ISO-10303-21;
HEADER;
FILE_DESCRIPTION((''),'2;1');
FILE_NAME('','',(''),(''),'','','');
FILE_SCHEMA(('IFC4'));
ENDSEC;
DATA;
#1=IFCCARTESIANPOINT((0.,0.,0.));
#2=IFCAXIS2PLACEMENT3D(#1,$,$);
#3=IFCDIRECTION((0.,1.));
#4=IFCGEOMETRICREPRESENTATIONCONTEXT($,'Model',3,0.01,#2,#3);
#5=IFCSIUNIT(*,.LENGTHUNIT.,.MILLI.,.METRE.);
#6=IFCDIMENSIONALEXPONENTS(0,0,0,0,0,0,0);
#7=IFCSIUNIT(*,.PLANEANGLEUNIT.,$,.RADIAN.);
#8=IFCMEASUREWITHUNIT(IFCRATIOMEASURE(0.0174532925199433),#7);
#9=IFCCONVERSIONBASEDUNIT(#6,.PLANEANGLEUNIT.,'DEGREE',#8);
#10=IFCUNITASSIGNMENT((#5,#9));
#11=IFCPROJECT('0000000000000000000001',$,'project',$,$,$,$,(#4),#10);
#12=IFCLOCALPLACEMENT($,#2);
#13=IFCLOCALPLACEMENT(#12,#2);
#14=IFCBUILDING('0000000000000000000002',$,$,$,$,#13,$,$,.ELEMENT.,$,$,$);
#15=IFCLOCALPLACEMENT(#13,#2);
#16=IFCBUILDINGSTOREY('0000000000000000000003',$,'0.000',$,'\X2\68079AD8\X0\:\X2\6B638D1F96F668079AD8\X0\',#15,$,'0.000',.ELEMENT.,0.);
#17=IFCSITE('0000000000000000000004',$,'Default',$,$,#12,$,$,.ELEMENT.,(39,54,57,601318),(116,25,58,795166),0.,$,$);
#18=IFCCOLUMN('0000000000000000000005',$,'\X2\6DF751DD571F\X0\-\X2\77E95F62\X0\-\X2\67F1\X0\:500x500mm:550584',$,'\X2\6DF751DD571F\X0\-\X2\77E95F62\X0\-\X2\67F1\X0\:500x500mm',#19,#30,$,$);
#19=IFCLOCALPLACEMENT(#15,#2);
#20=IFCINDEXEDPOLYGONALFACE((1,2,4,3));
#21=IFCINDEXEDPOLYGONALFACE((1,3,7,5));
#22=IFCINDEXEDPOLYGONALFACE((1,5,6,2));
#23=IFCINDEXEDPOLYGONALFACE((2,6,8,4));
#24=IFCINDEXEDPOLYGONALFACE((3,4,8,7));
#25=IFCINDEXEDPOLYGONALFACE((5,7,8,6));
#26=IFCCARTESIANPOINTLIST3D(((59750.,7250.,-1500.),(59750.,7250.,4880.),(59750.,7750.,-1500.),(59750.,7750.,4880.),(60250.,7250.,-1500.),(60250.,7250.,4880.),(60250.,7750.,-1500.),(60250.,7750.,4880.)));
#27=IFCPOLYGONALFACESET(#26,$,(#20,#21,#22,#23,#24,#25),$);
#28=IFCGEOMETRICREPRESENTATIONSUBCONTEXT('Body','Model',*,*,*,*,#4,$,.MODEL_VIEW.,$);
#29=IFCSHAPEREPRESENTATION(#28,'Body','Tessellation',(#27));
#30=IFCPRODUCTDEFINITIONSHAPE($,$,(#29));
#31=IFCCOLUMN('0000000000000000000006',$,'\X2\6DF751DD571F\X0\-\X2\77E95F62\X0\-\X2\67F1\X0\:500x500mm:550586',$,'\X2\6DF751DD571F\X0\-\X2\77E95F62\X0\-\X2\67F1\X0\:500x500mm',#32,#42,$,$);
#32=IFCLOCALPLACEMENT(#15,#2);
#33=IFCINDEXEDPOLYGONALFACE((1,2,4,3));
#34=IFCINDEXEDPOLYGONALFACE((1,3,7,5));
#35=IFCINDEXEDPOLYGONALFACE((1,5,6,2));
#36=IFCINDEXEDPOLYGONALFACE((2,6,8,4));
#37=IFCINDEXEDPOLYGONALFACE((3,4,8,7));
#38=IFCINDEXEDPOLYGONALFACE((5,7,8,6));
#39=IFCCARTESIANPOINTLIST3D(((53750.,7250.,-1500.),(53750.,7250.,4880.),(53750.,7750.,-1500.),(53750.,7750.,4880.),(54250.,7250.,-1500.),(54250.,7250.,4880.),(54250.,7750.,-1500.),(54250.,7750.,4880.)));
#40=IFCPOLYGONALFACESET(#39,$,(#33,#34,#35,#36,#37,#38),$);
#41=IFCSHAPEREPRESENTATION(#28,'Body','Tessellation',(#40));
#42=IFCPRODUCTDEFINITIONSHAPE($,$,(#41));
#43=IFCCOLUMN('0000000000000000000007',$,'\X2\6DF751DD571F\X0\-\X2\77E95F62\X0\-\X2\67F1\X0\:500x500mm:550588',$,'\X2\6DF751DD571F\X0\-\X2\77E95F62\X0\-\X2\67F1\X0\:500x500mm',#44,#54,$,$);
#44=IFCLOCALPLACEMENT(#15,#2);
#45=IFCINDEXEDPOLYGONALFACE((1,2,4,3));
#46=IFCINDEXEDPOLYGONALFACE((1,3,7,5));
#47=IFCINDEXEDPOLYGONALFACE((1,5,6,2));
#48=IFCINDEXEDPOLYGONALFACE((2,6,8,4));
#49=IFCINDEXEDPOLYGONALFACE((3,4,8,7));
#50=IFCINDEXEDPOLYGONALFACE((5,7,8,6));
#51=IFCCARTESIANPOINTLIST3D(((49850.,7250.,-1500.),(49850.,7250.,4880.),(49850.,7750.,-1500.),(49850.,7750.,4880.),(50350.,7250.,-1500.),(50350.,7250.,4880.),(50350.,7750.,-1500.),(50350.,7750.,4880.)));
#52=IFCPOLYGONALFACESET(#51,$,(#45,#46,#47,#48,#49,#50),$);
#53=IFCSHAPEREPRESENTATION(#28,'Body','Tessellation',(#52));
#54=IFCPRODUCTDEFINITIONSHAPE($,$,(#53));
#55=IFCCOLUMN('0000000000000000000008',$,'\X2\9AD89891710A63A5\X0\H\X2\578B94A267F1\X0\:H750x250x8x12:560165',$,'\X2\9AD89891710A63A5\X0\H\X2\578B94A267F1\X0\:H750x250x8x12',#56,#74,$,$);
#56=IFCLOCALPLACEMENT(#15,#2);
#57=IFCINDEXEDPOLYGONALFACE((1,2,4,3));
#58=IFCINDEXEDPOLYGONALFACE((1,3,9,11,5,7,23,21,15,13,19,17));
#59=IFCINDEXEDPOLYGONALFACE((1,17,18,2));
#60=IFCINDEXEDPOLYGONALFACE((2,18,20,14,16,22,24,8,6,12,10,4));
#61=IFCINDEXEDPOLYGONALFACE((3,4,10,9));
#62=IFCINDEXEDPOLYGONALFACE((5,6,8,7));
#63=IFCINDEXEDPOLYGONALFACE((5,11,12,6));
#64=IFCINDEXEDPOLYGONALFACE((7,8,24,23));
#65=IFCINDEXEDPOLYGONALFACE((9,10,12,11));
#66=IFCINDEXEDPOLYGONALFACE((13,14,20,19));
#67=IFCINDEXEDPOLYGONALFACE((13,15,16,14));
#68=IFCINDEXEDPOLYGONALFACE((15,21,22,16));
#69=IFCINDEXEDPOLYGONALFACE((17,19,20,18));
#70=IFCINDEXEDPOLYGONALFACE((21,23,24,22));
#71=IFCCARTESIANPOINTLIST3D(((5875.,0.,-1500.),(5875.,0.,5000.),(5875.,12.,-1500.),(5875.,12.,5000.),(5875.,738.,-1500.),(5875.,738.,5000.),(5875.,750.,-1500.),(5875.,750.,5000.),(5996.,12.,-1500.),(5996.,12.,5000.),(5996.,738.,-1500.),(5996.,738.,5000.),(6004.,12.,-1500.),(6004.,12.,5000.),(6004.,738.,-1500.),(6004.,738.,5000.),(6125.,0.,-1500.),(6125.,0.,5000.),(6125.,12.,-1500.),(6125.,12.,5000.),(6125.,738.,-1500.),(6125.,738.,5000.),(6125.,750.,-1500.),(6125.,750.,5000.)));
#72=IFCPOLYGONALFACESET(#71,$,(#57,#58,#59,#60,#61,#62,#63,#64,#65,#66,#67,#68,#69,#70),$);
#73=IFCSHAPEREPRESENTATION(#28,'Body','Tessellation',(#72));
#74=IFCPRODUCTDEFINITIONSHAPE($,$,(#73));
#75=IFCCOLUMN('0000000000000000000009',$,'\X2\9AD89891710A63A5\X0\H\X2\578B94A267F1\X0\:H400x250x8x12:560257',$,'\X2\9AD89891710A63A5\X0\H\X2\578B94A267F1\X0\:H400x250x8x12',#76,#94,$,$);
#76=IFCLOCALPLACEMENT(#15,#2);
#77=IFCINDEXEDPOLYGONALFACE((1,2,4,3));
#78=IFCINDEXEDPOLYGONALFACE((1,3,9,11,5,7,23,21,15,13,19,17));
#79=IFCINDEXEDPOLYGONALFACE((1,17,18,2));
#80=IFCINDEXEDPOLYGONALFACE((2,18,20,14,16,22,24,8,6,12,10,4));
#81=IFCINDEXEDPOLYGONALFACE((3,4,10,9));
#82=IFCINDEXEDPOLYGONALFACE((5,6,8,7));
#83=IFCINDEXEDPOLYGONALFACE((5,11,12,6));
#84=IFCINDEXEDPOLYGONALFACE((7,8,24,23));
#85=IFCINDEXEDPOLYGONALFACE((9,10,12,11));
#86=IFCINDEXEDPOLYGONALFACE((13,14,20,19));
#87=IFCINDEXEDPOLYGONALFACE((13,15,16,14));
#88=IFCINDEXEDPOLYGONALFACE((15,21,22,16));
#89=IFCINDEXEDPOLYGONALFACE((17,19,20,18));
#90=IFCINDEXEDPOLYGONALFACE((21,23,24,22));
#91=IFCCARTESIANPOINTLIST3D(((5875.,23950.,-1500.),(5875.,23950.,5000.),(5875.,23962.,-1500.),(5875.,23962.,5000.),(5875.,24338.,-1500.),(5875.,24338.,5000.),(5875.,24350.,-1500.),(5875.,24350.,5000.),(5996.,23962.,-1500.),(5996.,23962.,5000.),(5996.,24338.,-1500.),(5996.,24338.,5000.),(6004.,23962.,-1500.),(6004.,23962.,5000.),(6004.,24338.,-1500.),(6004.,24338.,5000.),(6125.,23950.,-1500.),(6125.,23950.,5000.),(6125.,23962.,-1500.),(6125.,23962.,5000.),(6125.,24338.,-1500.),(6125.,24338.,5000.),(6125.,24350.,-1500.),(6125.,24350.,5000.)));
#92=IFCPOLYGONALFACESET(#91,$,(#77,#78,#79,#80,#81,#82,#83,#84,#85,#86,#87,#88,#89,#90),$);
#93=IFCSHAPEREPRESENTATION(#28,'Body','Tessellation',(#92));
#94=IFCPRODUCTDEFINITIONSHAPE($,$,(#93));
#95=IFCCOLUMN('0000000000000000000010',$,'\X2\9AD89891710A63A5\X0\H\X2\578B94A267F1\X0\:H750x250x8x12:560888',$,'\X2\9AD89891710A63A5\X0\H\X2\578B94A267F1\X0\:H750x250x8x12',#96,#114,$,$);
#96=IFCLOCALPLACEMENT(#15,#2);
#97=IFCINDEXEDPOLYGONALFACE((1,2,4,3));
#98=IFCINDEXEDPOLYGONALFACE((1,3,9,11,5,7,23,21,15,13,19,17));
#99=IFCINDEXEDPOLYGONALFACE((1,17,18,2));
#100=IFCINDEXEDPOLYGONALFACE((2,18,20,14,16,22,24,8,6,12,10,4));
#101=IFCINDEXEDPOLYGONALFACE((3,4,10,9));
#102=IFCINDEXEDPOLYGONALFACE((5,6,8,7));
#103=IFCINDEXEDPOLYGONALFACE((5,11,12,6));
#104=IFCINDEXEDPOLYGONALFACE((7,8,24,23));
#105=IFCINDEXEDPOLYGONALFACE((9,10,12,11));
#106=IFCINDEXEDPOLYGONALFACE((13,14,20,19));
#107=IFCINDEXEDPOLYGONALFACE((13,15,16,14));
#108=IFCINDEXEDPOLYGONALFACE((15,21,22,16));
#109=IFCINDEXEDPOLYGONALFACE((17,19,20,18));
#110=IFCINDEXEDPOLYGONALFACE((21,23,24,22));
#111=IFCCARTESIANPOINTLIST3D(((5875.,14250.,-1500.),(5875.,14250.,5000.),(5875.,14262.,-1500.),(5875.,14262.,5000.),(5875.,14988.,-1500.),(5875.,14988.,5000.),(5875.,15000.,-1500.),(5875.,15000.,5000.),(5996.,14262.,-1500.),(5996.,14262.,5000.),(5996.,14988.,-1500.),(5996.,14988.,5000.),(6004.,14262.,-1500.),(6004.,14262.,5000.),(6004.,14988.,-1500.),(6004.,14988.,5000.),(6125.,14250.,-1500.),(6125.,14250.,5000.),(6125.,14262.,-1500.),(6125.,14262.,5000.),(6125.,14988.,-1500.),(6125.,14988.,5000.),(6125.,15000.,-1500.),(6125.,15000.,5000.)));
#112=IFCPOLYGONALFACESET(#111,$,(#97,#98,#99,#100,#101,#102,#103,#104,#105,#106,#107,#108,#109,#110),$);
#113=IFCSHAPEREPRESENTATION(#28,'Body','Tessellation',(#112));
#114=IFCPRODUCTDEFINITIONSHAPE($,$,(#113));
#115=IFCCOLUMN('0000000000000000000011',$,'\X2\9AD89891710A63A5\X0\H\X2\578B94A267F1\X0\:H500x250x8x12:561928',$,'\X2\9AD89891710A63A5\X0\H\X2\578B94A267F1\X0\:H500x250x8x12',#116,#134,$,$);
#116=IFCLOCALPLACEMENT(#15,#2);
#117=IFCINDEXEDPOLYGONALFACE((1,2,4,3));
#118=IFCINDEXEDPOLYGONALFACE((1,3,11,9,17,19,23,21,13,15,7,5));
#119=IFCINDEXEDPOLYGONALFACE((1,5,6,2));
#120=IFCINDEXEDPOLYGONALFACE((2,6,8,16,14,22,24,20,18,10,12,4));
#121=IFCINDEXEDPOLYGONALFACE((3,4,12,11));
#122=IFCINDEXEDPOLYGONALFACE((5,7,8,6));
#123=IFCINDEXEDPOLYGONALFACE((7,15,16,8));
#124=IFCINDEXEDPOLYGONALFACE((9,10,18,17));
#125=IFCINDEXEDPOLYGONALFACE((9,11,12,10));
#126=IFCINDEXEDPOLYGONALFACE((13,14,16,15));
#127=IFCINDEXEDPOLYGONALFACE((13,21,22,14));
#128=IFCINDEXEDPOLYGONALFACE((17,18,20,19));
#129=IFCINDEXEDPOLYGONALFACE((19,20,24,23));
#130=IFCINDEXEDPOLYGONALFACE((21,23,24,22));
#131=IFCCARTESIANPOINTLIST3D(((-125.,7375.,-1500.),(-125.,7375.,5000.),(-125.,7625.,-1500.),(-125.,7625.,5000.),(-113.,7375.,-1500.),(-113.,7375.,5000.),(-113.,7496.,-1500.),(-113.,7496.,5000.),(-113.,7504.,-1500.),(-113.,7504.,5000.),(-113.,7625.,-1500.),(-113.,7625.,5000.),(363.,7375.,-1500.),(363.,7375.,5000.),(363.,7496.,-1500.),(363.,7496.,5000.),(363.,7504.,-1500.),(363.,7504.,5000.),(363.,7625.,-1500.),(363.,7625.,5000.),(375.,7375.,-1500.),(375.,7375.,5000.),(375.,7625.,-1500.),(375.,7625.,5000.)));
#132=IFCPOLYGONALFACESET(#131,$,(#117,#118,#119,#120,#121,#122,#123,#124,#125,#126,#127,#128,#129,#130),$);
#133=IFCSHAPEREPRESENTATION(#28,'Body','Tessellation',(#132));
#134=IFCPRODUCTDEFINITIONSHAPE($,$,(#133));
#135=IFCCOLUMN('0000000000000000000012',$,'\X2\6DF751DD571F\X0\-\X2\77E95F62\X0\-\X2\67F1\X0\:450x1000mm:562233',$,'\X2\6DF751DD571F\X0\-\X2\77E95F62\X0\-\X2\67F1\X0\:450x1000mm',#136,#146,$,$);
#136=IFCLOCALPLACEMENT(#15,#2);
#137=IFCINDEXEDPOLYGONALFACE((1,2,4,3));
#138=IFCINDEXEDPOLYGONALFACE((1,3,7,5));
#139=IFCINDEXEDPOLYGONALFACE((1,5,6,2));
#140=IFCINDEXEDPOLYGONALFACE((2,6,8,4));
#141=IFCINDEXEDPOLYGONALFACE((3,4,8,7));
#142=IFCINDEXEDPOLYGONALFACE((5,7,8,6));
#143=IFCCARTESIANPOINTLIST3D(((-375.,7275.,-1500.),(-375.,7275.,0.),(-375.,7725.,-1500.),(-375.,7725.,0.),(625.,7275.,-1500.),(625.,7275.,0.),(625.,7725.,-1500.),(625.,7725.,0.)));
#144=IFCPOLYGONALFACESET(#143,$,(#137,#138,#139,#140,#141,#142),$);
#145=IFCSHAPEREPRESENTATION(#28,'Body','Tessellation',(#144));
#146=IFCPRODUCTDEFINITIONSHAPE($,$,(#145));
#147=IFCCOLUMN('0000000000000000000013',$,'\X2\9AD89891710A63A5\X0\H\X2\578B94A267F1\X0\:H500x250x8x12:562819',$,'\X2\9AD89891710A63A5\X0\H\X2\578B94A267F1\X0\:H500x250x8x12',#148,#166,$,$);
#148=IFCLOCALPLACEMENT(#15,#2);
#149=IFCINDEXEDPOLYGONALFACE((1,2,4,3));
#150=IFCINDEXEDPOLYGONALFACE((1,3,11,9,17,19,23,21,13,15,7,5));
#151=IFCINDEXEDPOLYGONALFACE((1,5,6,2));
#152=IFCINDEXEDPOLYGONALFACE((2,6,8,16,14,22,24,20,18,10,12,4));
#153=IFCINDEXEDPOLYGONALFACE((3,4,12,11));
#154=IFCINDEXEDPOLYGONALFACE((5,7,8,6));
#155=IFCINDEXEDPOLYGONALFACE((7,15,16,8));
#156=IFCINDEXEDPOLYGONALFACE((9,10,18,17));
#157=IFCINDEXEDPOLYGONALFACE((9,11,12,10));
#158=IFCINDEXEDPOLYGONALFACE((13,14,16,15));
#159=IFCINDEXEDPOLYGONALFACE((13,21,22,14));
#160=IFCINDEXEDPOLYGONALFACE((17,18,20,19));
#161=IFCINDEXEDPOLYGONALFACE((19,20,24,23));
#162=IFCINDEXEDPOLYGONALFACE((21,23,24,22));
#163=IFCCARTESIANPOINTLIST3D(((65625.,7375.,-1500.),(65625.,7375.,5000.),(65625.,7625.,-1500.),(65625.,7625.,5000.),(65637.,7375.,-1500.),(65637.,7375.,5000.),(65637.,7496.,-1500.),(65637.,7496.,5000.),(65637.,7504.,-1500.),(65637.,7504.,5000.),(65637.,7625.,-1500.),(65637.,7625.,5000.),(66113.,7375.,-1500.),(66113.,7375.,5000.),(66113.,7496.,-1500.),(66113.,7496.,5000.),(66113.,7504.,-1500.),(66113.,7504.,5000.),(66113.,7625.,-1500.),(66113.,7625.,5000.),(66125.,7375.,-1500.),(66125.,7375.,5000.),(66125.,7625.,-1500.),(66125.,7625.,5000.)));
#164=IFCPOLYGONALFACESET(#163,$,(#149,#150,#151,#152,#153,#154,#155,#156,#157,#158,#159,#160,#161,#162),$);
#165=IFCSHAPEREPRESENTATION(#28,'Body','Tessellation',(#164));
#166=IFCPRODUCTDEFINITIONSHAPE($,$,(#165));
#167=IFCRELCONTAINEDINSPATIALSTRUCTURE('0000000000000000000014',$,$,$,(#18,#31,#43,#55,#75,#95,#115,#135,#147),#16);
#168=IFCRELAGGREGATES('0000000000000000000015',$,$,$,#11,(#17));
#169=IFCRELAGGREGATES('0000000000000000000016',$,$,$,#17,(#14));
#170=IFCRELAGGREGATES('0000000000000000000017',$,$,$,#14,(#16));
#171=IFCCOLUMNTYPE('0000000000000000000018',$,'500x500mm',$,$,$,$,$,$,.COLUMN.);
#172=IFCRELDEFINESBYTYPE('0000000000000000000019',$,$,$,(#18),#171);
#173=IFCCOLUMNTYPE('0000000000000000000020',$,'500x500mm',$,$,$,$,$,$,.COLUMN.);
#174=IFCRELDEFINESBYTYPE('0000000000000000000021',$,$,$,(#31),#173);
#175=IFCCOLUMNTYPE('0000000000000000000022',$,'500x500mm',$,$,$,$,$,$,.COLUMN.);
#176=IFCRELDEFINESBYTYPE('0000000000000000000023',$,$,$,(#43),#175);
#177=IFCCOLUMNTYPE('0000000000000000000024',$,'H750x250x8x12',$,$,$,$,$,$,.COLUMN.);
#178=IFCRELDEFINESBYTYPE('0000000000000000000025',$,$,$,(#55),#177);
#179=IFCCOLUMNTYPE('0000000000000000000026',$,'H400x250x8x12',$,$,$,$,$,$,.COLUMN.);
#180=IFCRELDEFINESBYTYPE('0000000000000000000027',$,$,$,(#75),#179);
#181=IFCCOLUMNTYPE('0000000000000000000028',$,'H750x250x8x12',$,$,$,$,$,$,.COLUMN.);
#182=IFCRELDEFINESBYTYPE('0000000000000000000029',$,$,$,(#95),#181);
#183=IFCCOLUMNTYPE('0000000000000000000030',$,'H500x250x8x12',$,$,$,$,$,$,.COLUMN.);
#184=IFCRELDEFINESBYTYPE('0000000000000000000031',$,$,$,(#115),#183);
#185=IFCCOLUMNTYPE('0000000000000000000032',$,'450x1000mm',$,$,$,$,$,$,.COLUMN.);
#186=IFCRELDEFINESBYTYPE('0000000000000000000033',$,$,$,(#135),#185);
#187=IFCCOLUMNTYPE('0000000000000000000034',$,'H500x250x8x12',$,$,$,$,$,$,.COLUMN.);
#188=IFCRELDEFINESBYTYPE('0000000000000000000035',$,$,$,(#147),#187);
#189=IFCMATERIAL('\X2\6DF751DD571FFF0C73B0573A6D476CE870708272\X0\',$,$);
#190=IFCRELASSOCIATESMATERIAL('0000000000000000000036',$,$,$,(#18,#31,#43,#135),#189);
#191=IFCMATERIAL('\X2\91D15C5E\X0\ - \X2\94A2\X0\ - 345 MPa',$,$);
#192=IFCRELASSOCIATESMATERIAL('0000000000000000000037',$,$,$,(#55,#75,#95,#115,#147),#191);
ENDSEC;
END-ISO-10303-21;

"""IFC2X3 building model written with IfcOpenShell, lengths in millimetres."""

from ifc_helpers import new_model, entity, si_unit, converted_unit, direction, frame, frame_2d, origin, origin_2d_with_axis, place, context, subcontext, project, spatial, polyline, rectangle, i_section, outline, extrude, source, transform, mapped, material, type_object, type_shapes, element, save


model = new_model("IFC2X3")

# Units and contexts
model_context = context("Model", 3, precision=0.01, world=origin(), true_north=direction((0.0, 1.0)))
body_context = subcontext(model_context, "Body", "Model", "MODEL_VIEW")
ifc_project = project(units=[si_unit("LENGTHUNIT", "METRE", prefix="MILLI"), converted_unit("PLANEANGLEUNIT", "DEGREE", entity("IfcRatioMeasure", 0.0174532925199433), si_unit("PLANEANGLEUNIT", "RADIAN"), dimensions=[0, 0, 0, 0, 0, 0, 0])], contexts=[model_context])

# Site, building, storey
site_placement = place(None, origin())
site = spatial("IfcSite", under=ifc_project, at=site_placement, Name="Default", CompositionType="ELEMENT", RefLatitude=(39, 54, 57, 601318), RefLongitude=(116, 25, 58, 795166), RefElevation=0.0)
building_placement = place(site_placement, origin())
building = spatial("IfcBuilding", under=site, at=building_placement, CompositionType="ELEMENT")
storey_placement = place(building_placement, origin())
storey = spatial("IfcBuildingStorey", under=building, at=storey_placement, Name="0.000", ObjectType="标高:正负零标高", LongName="0.000", CompositionType="ELEMENT", Elevation=0.0)

# Columns
ifc_material_1 = material(Name="混凝土，现场浇注灰色")
column_type_1 = type_object("IfcColumnType", Name="500x500mm", PredefinedType="COLUMN")
shared_shape_1 = source(origin(), body_context, "Body", "SweptSolid", [
    extrude(rectangle(XDim=500.0, YDim=500.0, at=origin_2d_with_axis()), frame((60000.0, 7500.0, -1500.0), z_axis=(0.0, 0.0, 1.0), x_axis=(0.0, -1.0, 0.0)), (0.0, 0.0, 1.0), 6380.0),
])
type_shapes(column_type_1, [shared_shape_1])
column_1_placement = place(storey_placement, origin())
element("IfcColumn", 1, at=column_1_placement, inside=storey, type_object=column_type_1, material=ifc_material_1, Name="混凝土-矩形-柱:500x500mm:550584", ObjectType="混凝土-矩形-柱:500x500mm", context=body_context, shape_type="MappedRepresentation", body=[
    mapped(shared_shape_1, transform((0.0, 0.0, 0.0), scale=1.0)),
])
column_type_2 = type_object("IfcColumnType", Name="500x500mm", PredefinedType="COLUMN")
shared_shape_2 = source(origin(), body_context, "Body", "SweptSolid", [
    extrude(rectangle(XDim=500.0, YDim=500.0, at=origin_2d_with_axis()), frame((54000.0, 7500.0, -1500.0), z_axis=(0.0, 0.0, 1.0), x_axis=(0.0, -1.0, 0.0)), (0.0, 0.0, 1.0), 6380.0),
])
type_shapes(column_type_2, [shared_shape_2])
column_2_placement = place(storey_placement, origin())
element("IfcColumn", 2, at=column_2_placement, inside=storey, type_object=column_type_2, material=ifc_material_1, Name="混凝土-矩形-柱:500x500mm:550586", ObjectType="混凝土-矩形-柱:500x500mm", context=body_context, shape_type="MappedRepresentation", body=[
    mapped(shared_shape_2, transform((0.0, 0.0, 0.0), scale=1.0)),
])
column_type_3 = type_object("IfcColumnType", Name="500x500mm", PredefinedType="COLUMN")
shared_shape_3 = source(origin(), body_context, "Body", "SweptSolid", [
    extrude(rectangle(XDim=500.0, YDim=500.0, at=origin_2d_with_axis()), frame((50100.0, 7500.0, -1500.0), z_axis=(0.0, 0.0, 1.0), x_axis=(0.0, -1.0, 0.0)), (0.0, 0.0, 1.0), 6380.0),
])
type_shapes(column_type_3, [shared_shape_3])
column_3_placement = place(storey_placement, origin())
element("IfcColumn", 3, at=column_3_placement, inside=storey, type_object=column_type_3, material=ifc_material_1, Name="混凝土-矩形-柱:500x500mm:550588", ObjectType="混凝土-矩形-柱:500x500mm", context=body_context, shape_type="MappedRepresentation", body=[
    mapped(shared_shape_3, transform((0.0, 0.0, 0.0), scale=1.0)),
])
ifc_material_2 = material(Name="金属 - 钢 - 345 MPa")
column_type_4 = type_object("IfcColumnType", Name="H750x250x8x12", PredefinedType="COLUMN")
shared_shape_4 = source(origin(), body_context, "Body", "SweptSolid", [
    extrude(outline(polyline([(363.0, -125.0), (375.0, -125.0), (375.0, 125.0), (363.0, 125.0), (363.0, 4.0), (-363.0, 4.0), (-363.0, 125.0), (-375.0, 125.0), (-375.0, -125.0), (-363.0, -125.0), (-363.0, -4.0), (363.0, -4.0), (363.0, -125.0)])), frame((6000.0, 375.0, -1500.0), z_axis=(0.0, 0.0, 1.0), x_axis=(0.0, -1.0, 0.0)), (0.0, 0.0, 1.0), 6500.0),
])
type_shapes(column_type_4, [shared_shape_4])
column_4_placement = place(storey_placement, origin())
element("IfcColumn", 4, at=column_4_placement, inside=storey, type_object=column_type_4, material=ifc_material_2, Name="高频焊接H型钢柱:H750x250x8x12:560165", ObjectType="高频焊接H型钢柱:H750x250x8x12", context=body_context, shape_type="MappedRepresentation", body=[
    mapped(shared_shape_4, transform((0.0, 0.0, 0.0), scale=1.0)),
])
column_type_5 = type_object("IfcColumnType", Name="H400x250x8x12", PredefinedType="COLUMN")
shared_shape_5 = source(origin(), body_context, "Body", "SweptSolid", [
    extrude(outline(polyline([(188.0, -125.0), (200.0, -125.0), (200.0, 125.0), (188.0, 125.0), (188.0, 4.0), (-188.0, 4.0), (-188.0, 125.0), (-200.0, 125.0), (-200.0, -125.0), (-188.0, -125.0), (-188.0, -4.0), (188.0, -4.0), (188.0, -125.0)])), frame((6000.0, 24150.0, -1500.0), z_axis=(0.0, 0.0, 1.0), x_axis=(0.0, -1.0, 0.0)), (0.0, 0.0, 1.0), 6500.0),
])
type_shapes(column_type_5, [shared_shape_5])
column_5_placement = place(storey_placement, origin())
element("IfcColumn", 5, at=column_5_placement, inside=storey, type_object=column_type_5, material=ifc_material_2, Name="高频焊接H型钢柱:H400x250x8x12:560257", ObjectType="高频焊接H型钢柱:H400x250x8x12", context=body_context, shape_type="MappedRepresentation", body=[
    mapped(shared_shape_5, transform((0.0, 0.0, 0.0), scale=1.0)),
])
column_type_6 = type_object("IfcColumnType", Name="H750x250x8x12", PredefinedType="COLUMN")
shared_shape_6 = source(origin(), body_context, "Body", "SweptSolid", [
    extrude(outline(polyline([(363.0, -125.0), (375.0, -125.0), (375.0, 125.0), (363.0, 125.0), (363.0, 4.0), (-363.0, 4.0), (-363.0, 125.0), (-375.0, 125.0), (-375.0, -125.0), (-363.0, -125.0), (-363.0, -4.0), (363.0, -4.0), (363.0, -125.0)])), frame((6000.0, 14625.0, -1500.0), z_axis=(0.0, 0.0, 1.0), x_axis=(0.0, -1.0, 0.0)), (0.0, 0.0, 1.0), 6500.0),
])
type_shapes(column_type_6, [shared_shape_6])
column_6_placement = place(storey_placement, origin())
element("IfcColumn", 6, at=column_6_placement, inside=storey, type_object=column_type_6, material=ifc_material_2, Name="高频焊接H型钢柱:H750x250x8x12:560888", ObjectType="高频焊接H型钢柱:H750x250x8x12", context=body_context, shape_type="MappedRepresentation", body=[
    mapped(shared_shape_6, transform((0.0, 0.0, 0.0), scale=1.0)),
])
column_type_7 = type_object("IfcColumnType", Name="H500x250x8x12", PredefinedType="COLUMN")
shared_shape_7 = source(origin(), body_context, "Body", "SweptSolid", [
    extrude(i_section(OverallWidth=250.0, OverallDepth=500.0, WebThickness=8.0, FlangeThickness=12.0, at=frame_2d((0.0, 0.0), x_axis=(1.0, 0.0))), frame((125.0, 7500.0, -1500.0), z_axis=(0.0, 0.0, 1.0), x_axis=(0.0, -1.0, 0.0)), (0.0, 0.0, 1.0), 6500.0),
])
type_shapes(column_type_7, [shared_shape_7])
column_7_placement = place(storey_placement, origin())
element("IfcColumn", 7, at=column_7_placement, inside=storey, type_object=column_type_7, material=ifc_material_2, Name="高频焊接H型钢柱:H500x250x8x12:561928", ObjectType="高频焊接H型钢柱:H500x250x8x12", context=body_context, shape_type="MappedRepresentation", body=[
    mapped(shared_shape_7, transform((0.0, 0.0, 0.0), scale=1.0)),
])
column_type_8 = type_object("IfcColumnType", Name="450x1000mm", PredefinedType="COLUMN")
shared_shape_8 = source(origin(), body_context, "Body", "SweptSolid", [
    extrude(rectangle(XDim=450.0, YDim=1000.0, at=frame_2d((0.0, 0.0), x_axis=(1.0, 0.0))), frame((125.0, 7500.0, -1500.0), z_axis=(0.0, 0.0, 1.0), x_axis=(0.0, -1.0, 0.0)), (0.0, 0.0, 1.0), 1500.0),
])
type_shapes(column_type_8, [shared_shape_8])
column_8_placement = place(storey_placement, origin())
element("IfcColumn", 8, at=column_8_placement, inside=storey, type_object=column_type_8, material=ifc_material_1, Name="混凝土-矩形-柱:450x1000mm:562233", ObjectType="混凝土-矩形-柱:450x1000mm", context=body_context, shape_type="MappedRepresentation", body=[
    mapped(shared_shape_8, transform((0.0, 0.0, 0.0), scale=1.0)),
])
column_type_9 = type_object("IfcColumnType", Name="H500x250x8x12", PredefinedType="COLUMN")
shared_shape_9 = source(origin(), body_context, "Body", "SweptSolid", [
    extrude(i_section(OverallWidth=250.0, OverallDepth=500.0, WebThickness=8.0, FlangeThickness=12.0, at=frame_2d((0.0, 0.0), x_axis=(1.0, 0.0))), frame((65875.0, 7500.0, -1500.0), z_axis=(0.0, 0.0, 1.0), x_axis=(0.0, -1.0, 0.0)), (0.0, 0.0, 1.0), 6500.0),
])
type_shapes(column_type_9, [shared_shape_9])
column_9_placement = place(storey_placement, origin())
element("IfcColumn", 9, at=column_9_placement, inside=storey, type_object=column_type_9, material=ifc_material_2, Name="高频焊接H型钢柱:H500x250x8x12:562819", ObjectType="高频焊接H型钢柱:H500x250x8x12", context=body_context, shape_type="MappedRepresentation", body=[
    mapped(shared_shape_9, transform((0.0, 0.0, 0.0), scale=1.0)),
])

save(model, "model.ifc")
